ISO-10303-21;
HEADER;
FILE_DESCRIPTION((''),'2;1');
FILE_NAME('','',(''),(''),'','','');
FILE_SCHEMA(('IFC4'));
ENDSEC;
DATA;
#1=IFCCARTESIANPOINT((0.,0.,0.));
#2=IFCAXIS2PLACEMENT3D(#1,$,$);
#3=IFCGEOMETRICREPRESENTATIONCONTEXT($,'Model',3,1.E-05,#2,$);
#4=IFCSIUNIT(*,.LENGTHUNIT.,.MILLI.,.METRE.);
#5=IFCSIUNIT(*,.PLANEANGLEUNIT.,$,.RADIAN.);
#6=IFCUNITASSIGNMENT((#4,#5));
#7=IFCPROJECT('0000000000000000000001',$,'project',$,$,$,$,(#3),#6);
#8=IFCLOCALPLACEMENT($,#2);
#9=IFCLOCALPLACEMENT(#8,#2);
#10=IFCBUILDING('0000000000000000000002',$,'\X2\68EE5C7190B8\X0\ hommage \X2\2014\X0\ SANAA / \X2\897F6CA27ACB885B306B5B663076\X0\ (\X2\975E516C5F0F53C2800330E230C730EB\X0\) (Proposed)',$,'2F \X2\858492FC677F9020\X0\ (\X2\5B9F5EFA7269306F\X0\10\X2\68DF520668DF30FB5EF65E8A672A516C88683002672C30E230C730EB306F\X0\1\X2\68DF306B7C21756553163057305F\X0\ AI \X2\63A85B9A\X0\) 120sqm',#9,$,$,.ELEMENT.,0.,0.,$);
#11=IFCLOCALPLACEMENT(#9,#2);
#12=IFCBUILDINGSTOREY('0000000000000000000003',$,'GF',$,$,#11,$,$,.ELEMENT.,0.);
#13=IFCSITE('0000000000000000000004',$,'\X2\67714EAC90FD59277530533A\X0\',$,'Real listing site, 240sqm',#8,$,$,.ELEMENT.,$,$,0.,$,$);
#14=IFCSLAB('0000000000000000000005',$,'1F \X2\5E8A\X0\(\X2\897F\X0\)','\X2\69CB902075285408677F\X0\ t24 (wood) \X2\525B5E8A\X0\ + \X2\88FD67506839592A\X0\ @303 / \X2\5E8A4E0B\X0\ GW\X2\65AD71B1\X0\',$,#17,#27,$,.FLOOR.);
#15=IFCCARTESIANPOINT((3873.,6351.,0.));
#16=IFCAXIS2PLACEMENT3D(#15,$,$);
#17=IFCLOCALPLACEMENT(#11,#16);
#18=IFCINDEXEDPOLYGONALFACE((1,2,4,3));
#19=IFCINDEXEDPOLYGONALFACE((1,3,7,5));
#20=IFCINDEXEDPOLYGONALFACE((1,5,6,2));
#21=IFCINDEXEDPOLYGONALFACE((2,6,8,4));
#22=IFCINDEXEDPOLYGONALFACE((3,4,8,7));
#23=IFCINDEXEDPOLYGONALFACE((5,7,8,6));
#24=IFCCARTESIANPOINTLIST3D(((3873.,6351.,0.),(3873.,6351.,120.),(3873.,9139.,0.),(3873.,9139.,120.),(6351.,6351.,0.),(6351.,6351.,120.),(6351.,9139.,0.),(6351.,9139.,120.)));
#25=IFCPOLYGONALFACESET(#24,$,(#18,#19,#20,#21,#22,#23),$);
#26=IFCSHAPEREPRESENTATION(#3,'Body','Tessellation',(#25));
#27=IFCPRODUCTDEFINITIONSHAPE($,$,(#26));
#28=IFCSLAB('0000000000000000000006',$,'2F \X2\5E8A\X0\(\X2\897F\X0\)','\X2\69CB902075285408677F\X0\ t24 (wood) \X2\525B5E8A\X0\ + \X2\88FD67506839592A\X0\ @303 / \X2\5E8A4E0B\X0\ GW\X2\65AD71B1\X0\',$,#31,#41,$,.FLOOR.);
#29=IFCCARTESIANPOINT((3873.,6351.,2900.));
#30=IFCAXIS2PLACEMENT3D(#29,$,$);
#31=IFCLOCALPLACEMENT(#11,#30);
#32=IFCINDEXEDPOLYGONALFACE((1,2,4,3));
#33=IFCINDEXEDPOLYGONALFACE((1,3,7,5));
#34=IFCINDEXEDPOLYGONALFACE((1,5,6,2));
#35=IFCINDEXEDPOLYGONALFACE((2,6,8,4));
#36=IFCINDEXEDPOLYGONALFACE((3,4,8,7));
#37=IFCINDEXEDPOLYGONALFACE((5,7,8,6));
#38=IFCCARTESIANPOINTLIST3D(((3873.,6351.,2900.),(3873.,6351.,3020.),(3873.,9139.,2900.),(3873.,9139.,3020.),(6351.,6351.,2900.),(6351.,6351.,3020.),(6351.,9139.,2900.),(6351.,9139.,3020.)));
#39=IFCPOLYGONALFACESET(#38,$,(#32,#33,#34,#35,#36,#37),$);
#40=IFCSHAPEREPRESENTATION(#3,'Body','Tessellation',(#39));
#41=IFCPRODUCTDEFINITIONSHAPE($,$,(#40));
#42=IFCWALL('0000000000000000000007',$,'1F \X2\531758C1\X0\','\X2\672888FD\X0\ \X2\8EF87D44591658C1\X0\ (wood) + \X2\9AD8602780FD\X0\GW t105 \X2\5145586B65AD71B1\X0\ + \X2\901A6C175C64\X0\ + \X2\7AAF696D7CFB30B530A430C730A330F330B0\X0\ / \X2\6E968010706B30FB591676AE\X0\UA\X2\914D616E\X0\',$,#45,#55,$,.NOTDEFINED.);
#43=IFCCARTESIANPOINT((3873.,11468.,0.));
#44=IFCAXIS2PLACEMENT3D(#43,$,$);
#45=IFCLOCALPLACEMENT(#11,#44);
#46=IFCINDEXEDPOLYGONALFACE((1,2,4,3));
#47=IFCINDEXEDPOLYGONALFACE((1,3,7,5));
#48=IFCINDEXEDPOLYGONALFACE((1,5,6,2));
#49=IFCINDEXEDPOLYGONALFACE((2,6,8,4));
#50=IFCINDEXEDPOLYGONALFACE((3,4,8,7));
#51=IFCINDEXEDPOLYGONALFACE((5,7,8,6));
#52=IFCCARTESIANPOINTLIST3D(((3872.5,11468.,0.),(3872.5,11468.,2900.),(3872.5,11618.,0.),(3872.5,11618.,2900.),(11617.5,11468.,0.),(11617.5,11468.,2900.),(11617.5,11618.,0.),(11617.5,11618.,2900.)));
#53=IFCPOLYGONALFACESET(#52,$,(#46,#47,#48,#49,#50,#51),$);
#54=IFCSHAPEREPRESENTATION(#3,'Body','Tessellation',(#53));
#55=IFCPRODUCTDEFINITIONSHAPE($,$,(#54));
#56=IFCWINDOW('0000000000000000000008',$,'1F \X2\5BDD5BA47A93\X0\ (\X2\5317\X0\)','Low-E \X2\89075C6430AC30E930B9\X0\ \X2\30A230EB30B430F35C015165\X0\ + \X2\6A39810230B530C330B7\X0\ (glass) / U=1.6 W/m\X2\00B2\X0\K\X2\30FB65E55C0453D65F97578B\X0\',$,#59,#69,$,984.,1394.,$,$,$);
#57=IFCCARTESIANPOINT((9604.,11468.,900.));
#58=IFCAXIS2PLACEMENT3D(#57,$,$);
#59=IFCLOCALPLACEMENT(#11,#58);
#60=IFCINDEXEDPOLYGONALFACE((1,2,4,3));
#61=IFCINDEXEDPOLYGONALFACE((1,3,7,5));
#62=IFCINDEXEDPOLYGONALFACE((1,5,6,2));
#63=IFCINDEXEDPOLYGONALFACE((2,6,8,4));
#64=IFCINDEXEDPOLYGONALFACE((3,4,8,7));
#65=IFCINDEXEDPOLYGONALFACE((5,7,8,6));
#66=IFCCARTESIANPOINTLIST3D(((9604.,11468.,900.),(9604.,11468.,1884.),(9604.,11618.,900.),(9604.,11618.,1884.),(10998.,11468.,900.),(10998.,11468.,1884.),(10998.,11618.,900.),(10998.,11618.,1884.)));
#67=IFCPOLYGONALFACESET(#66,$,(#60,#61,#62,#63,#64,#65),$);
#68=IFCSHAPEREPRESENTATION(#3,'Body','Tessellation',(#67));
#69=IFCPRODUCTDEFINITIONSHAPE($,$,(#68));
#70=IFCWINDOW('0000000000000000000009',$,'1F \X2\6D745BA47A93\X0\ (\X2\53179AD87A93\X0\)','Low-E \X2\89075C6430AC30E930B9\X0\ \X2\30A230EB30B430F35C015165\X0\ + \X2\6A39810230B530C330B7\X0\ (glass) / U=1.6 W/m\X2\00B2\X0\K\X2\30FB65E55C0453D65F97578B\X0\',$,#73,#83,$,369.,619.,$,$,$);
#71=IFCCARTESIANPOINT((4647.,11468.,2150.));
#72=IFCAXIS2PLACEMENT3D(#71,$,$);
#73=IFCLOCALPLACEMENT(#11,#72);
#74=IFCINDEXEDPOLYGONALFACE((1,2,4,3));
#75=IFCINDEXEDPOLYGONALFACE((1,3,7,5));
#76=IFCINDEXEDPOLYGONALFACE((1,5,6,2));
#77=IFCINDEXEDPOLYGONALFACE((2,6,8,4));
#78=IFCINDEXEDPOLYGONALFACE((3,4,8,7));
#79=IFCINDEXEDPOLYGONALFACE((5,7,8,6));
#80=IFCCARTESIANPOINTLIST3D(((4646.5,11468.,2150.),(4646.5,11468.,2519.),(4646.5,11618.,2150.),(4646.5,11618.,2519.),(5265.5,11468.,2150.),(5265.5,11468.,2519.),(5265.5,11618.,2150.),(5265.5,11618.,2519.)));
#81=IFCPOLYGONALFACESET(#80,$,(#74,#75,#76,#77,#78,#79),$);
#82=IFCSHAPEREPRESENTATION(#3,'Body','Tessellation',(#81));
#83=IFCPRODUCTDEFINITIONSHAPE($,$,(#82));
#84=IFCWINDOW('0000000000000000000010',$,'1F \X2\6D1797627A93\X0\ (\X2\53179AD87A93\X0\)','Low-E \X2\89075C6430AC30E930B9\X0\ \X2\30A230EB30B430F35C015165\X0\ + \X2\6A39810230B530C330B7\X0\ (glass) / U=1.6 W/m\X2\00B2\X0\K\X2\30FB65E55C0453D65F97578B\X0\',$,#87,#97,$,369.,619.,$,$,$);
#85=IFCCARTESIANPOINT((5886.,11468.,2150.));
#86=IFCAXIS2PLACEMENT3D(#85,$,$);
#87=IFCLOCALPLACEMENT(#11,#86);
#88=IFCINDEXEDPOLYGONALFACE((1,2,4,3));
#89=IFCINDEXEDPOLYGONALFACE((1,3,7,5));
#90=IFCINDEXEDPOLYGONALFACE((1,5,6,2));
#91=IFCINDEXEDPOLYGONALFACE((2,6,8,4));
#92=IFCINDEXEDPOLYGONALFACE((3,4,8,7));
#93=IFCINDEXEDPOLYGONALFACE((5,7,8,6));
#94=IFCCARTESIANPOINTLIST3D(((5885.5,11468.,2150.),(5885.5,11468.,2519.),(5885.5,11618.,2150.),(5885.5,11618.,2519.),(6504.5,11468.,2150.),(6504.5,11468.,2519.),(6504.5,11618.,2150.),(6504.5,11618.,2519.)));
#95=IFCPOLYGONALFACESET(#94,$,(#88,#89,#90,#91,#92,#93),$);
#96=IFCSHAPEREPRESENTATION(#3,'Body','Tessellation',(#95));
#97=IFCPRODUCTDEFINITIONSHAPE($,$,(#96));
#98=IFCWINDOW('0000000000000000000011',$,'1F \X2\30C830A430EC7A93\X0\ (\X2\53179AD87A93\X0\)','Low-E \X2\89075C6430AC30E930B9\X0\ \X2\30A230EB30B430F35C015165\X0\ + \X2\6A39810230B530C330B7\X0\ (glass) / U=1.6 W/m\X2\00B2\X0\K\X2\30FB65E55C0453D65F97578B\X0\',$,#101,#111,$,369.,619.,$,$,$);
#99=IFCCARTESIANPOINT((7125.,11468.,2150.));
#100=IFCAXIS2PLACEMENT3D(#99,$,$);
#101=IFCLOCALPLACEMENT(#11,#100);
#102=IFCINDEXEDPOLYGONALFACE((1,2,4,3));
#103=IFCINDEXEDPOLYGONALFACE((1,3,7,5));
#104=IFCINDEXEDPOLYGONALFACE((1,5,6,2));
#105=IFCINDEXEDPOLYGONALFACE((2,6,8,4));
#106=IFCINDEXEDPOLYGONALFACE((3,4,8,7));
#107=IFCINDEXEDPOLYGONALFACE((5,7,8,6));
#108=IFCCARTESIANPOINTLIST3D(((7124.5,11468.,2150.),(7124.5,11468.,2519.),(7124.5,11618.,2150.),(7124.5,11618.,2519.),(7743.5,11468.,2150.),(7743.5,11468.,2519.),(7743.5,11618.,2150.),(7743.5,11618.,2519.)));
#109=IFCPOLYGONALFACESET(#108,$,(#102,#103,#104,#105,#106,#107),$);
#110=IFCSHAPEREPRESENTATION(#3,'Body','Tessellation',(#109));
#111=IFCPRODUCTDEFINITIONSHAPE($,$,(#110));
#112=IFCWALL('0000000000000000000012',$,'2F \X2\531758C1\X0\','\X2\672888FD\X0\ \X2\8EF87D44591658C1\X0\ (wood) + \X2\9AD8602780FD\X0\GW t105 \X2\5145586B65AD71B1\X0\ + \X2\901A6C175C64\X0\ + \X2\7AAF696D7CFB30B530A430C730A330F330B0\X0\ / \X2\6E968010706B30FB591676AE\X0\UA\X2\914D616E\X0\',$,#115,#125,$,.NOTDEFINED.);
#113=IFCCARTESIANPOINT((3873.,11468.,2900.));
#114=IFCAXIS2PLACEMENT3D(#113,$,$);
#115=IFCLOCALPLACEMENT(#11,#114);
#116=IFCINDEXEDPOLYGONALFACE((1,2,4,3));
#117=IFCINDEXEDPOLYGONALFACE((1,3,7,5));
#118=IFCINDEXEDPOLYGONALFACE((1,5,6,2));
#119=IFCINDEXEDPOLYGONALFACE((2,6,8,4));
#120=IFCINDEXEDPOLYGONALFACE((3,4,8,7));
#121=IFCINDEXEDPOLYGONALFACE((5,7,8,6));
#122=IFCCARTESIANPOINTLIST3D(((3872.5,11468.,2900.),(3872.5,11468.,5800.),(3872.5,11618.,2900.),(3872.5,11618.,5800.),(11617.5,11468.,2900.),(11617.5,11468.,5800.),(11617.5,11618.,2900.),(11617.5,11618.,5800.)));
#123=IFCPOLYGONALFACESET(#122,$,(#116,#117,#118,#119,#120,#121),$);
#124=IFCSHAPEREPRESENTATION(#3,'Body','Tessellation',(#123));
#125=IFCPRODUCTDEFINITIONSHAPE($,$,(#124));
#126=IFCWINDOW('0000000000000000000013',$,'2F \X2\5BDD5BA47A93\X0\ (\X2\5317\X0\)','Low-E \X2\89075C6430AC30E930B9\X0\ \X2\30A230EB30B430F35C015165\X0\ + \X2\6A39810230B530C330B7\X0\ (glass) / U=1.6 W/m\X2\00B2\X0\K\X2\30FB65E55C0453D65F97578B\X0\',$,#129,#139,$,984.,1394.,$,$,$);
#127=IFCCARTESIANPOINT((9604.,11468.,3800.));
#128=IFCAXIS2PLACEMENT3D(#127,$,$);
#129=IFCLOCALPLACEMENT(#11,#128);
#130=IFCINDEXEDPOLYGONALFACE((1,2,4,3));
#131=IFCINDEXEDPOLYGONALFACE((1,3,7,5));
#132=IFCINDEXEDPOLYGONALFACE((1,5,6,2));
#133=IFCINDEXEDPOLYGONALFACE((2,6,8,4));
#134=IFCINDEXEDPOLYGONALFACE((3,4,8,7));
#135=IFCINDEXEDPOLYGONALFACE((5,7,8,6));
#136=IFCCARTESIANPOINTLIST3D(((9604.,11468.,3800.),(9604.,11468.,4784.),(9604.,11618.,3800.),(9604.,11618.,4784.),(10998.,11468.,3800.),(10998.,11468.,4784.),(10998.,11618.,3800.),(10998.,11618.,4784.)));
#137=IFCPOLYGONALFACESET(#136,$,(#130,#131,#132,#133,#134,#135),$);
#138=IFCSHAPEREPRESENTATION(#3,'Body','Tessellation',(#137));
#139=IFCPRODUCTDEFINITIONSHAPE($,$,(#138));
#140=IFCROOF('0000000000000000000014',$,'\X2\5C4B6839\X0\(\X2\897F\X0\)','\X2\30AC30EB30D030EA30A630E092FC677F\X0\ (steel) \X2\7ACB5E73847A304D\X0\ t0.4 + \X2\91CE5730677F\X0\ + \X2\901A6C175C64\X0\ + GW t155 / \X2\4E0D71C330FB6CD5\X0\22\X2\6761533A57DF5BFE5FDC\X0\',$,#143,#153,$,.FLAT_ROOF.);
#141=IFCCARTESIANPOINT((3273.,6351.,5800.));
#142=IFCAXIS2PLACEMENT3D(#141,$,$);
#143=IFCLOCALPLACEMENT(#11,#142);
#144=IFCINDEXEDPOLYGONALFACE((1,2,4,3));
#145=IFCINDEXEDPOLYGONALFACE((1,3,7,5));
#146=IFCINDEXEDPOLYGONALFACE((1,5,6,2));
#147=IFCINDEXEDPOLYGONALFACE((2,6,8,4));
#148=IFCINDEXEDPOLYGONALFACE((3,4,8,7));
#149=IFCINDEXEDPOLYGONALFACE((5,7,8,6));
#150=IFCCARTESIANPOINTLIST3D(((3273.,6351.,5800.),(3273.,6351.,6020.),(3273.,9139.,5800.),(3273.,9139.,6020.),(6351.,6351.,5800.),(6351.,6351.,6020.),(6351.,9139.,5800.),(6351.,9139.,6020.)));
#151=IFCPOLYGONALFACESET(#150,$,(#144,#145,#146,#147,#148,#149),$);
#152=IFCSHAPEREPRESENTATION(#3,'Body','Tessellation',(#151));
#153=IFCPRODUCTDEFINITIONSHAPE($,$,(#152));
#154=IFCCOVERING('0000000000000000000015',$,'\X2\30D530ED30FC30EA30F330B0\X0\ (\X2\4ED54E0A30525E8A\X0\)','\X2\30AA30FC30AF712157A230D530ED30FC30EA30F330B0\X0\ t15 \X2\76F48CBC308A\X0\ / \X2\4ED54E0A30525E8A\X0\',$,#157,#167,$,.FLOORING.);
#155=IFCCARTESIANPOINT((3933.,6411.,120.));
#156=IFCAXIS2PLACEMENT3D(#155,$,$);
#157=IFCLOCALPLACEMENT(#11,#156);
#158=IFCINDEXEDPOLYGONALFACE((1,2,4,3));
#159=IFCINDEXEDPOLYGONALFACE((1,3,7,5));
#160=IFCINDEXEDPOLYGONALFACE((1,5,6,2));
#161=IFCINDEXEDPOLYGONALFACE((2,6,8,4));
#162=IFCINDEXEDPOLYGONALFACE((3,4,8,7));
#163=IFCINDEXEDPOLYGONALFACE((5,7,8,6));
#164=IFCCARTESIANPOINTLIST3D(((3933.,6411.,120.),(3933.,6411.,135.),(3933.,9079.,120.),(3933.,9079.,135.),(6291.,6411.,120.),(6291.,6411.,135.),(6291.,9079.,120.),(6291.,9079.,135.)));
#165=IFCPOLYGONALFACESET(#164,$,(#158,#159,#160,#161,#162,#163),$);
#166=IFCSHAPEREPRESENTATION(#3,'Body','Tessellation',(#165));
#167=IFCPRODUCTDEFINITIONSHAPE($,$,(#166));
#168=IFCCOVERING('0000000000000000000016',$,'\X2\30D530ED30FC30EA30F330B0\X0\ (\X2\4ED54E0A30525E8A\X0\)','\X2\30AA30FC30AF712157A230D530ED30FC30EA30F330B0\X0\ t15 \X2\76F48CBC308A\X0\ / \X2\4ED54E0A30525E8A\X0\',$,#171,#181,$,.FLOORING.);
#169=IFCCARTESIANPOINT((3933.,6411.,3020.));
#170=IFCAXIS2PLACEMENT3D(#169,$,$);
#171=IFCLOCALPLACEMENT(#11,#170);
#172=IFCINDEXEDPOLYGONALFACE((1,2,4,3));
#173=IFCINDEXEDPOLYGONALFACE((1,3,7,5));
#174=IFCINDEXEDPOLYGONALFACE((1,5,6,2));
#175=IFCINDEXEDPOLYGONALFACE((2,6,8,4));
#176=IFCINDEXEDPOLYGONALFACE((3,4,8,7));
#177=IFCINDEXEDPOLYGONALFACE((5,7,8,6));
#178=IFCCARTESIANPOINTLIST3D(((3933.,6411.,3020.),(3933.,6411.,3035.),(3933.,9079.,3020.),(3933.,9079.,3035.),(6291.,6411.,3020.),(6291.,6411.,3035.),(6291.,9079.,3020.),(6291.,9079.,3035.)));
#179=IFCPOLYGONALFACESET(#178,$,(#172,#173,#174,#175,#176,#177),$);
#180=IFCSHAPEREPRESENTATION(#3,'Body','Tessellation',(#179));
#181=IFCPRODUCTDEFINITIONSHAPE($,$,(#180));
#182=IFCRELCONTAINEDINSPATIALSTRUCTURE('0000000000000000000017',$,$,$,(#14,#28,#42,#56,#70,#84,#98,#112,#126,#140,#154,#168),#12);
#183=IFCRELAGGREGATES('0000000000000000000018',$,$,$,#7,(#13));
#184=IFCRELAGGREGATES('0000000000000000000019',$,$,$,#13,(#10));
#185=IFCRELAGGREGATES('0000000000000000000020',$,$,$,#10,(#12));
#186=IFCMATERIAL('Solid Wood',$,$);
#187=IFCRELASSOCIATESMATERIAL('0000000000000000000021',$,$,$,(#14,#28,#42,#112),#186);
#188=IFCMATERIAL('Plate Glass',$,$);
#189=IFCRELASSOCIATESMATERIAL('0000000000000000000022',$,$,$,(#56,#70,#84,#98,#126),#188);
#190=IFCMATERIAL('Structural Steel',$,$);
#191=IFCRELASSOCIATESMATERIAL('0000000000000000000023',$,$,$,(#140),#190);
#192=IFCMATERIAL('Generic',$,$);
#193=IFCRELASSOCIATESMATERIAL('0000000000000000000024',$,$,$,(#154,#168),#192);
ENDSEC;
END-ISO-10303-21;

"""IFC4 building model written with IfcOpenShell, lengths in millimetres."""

from ifc_helpers import new_model, si_unit, frame, frame_2d, origin, place, context, project, spatial, rectangle, extrude, material, element, fill, save


model = new_model("IFC4")

# Units and contexts
model_context = context("Model", 3, precision=1e-05, world=origin())
ifc_project = project(units=[si_unit("LENGTHUNIT", "METRE", prefix="MILLI"), si_unit("PLANEANGLEUNIT", "RADIAN")], contexts=[model_context])

# Site, building, storey
site_placement = place(None, origin())
site = spatial("IfcSite", under=ifc_project, at=site_placement, Name="東京都大田区", ObjectType="Real listing site, 240sqm", CompositionType="ELEMENT", RefElevation=0.0)
building_placement = place(site_placement, origin())
building = spatial("IfcBuilding", under=site, at=building_placement, Name="森山邸 hommage — SANAA / 西沢立衛に学ぶ (非公式参考モデル) (Proposed)", ObjectType="2F 薄鋼板造 (実建物は10棟分棟・延床未公表。本モデルは1棟に簡略化した AI 推定) 120sqm", CompositionType="ELEMENT", ElevationOfRefHeight=0.0, ElevationOfTerrain=0.0)
storey_placement = place(building_placement, origin())
storey = spatial("IfcBuildingStorey", under=building, at=storey_placement, Name="GF", CompositionType="ELEMENT", Elevation=0.0)

# Slabs
ifc_material_1 = material(Name="Solid Wood")
slab_1_placement = place(storey_placement, frame((3873.0, 6351.0, 0.0)))
element("IfcSlab", 1, at=slab_1_placement, inside=storey, material=ifc_material_1, Name="1F 床(西)", Description="構造用合板 t24 (wood) 剛床 + 製材根太 @303 / 床下 GW断熱", PredefinedType="FLOOR", context=model_context, shape_type="SweptSolid", body=[
    extrude(rectangle(XDim=2478.0, YDim=2788.0, at=frame_2d((1239.0, 1394.0))), frame((3873.0, 6351.0, 0.0)), (0.0, 0.0, 1.0), 120.0),
])
slab_2_placement = place(storey_placement, frame((3873.0, 6351.0, 2900.0)))
element("IfcSlab", 2, at=slab_2_placement, inside=storey, material=ifc_material_1, Name="2F 床(西)", Description="構造用合板 t24 (wood) 剛床 + 製材根太 @303 / 床下 GW断熱", PredefinedType="FLOOR", context=model_context, shape_type="SweptSolid", body=[
    extrude(rectangle(XDim=2478.0, YDim=2788.0, at=frame_2d((1239.0, 1394.0))), frame((3873.0, 6351.0, 2900.0)), (0.0, 0.0, 1.0), 120.0),
])

# Wall, openings, windows
wall_1_placement = place(storey_placement, frame((3873.0, 11468.0, 0.0)))
wall_1 = element("IfcWall", 3, at=wall_1_placement, inside=storey, material=ifc_material_1, Name="1F 北壁", Description="木製 軸組外壁 (wood) + 高性能GW t105 充填断熱 + 通気層 + 窯業系サイディング / 準耐火・外皮UA配慮", PredefinedType="NOTDEFINED", context=model_context, shape_type="SweptSolid", body=[
    extrude(rectangle(XDim=7745.0, YDim=150.0, at=frame_2d((3872.0, 75.0))), frame((3873.0, 11468.0, 0.0)), (0.0, 0.0, 1.0), 2900.0),
])
opening_1_placement = place(storey_placement, frame((9604.0, 11468.0, 900.0)))
opening_1 = element("IfcOpeningElement", 4, at=opening_1_placement, cuts=wall_1, PredefinedType="NOTDEFINED", context=model_context, shape_type="SweptSolid", body=[
    extrude(rectangle(XDim=1394.0, YDim=150.0, at=frame_2d((697.0, 75.0))), frame((9604.0, 11468.0, 900.0)), (0.0, 0.0, 1.0), 984.0),
])
opening_2_placement = place(storey_placement, frame((4647.0, 11468.0, 2150.0)))
opening_2 = element("IfcOpeningElement", 5, at=opening_2_placement, cuts=wall_1, PredefinedType="NOTDEFINED", context=model_context, shape_type="SweptSolid", body=[
    extrude(rectangle(XDim=619.0, YDim=150.0, at=frame_2d((309.0, 75.0))), frame((4647.0, 11468.0, 2150.0)), (0.0, 0.0, 1.0), 369.0),
])
opening_3_placement = place(storey_placement, frame((5886.0, 11468.0, 2150.0)))
opening_3 = element("IfcOpeningElement", 6, at=opening_3_placement, cuts=wall_1, PredefinedType="NOTDEFINED", context=model_context, shape_type="SweptSolid", body=[
    extrude(rectangle(XDim=619.0, YDim=150.0, at=frame_2d((309.0, 75.0))), frame((5886.0, 11468.0, 2150.0)), (0.0, 0.0, 1.0), 369.0),
])
opening_4_placement = place(storey_placement, frame((7125.0, 11468.0, 2150.0)))
opening_4 = element("IfcOpeningElement", 7, at=opening_4_placement, cuts=wall_1, PredefinedType="NOTDEFINED", context=model_context, shape_type="SweptSolid", body=[
    extrude(rectangle(XDim=619.0, YDim=150.0, at=frame_2d((309.0, 75.0))), frame((7125.0, 11468.0, 2150.0)), (0.0, 0.0, 1.0), 369.0),
])
ifc_material_2 = material(Name="Plate Glass")
window_1_placement = place(storey_placement, frame((9604.0, 11468.0, 900.0)))
window_1 = element("IfcWindow", 8, at=window_1_placement, inside=storey, material=ifc_material_2, Name="1F 寝室窓 (北)", Description="Low-E 複層ガラス アルゴン封入 + 樹脂サッシ (glass) / U=1.6 W/m²K・日射取得型", OverallHeight=984.0, OverallWidth=1394.0, context=model_context, shape_type="SweptSolid", body=[
    extrude(rectangle(XDim=1394.0, YDim=150.0, at=frame_2d((697.0, 75.0))), frame((9604.0, 11468.0, 900.0)), (0.0, 0.0, 1.0), 984.0),
])
fill(opening_1, window_1)
window_2_placement = place(storey_placement, frame((4647.0, 11468.0, 2150.0)))
window_2 = element("IfcWindow", 9, at=window_2_placement, inside=storey, material=ifc_material_2, Name="1F 浴室窓 (北高窓)", Description="Low-E 複層ガラス アルゴン封入 + 樹脂サッシ (glass) / U=1.6 W/m²K・日射取得型", OverallHeight=369.0, OverallWidth=619.0, context=model_context, shape_type="SweptSolid", body=[
    extrude(rectangle(XDim=619.0, YDim=150.0, at=frame_2d((309.0, 75.0))), frame((4647.0, 11468.0, 2150.0)), (0.0, 0.0, 1.0), 369.0),
])
fill(opening_2, window_2)
window_3_placement = place(storey_placement, frame((5886.0, 11468.0, 2150.0)))
window_3 = element("IfcWindow", 10, at=window_3_placement, inside=storey, material=ifc_material_2, Name="1F 洗面窓 (北高窓)", Description="Low-E 複層ガラス アルゴン封入 + 樹脂サッシ (glass) / U=1.6 W/m²K・日射取得型", OverallHeight=369.0, OverallWidth=619.0, context=model_context, shape_type="SweptSolid", body=[
    extrude(rectangle(XDim=619.0, YDim=150.0, at=frame_2d((309.0, 75.0))), frame((5886.0, 11468.0, 2150.0)), (0.0, 0.0, 1.0), 369.0),
])
fill(opening_3, window_3)
window_4_placement = place(storey_placement, frame((7125.0, 11468.0, 2150.0)))
window_4 = element("IfcWindow", 11, at=window_4_placement, inside=storey, material=ifc_material_2, Name="1F トイレ窓 (北高窓)", Description="Low-E 複層ガラス アルゴン封入 + 樹脂サッシ (glass) / U=1.6 W/m²K・日射取得型", OverallHeight=369.0, OverallWidth=619.0, context=model_context, shape_type="SweptSolid", body=[
    extrude(rectangle(XDim=619.0, YDim=150.0, at=frame_2d((309.0, 75.0))), frame((7125.0, 11468.0, 2150.0)), (0.0, 0.0, 1.0), 369.0),
])
fill(opening_4, window_4)

# Wall, opening, window
wall_2_placement = place(storey_placement, frame((3873.0, 11468.0, 2900.0)))
wall_2 = element("IfcWall", 12, at=wall_2_placement, inside=storey, material=ifc_material_1, Name="2F 北壁", Description="木製 軸組外壁 (wood) + 高性能GW t105 充填断熱 + 通気層 + 窯業系サイディング / 準耐火・外皮UA配慮", PredefinedType="NOTDEFINED", context=model_context, shape_type="SweptSolid", body=[
    extrude(rectangle(XDim=7745.0, YDim=150.0, at=frame_2d((3872.0, 75.0))), frame((3873.0, 11468.0, 2900.0)), (0.0, 0.0, 1.0), 2900.0),
])
opening_5_placement = place(storey_placement, frame((9604.0, 11468.0, 3800.0)))
opening_5 = element("IfcOpeningElement", 13, at=opening_5_placement, cuts=wall_2, PredefinedType="NOTDEFINED", context=model_context, shape_type="SweptSolid", body=[
    extrude(rectangle(XDim=1394.0, YDim=150.0, at=frame_2d((697.0, 75.0))), frame((9604.0, 11468.0, 3800.0)), (0.0, 0.0, 1.0), 984.0),
])
window_5_placement = place(storey_placement, frame((9604.0, 11468.0, 3800.0)))
window_5 = element("IfcWindow", 14, at=window_5_placement, inside=storey, material=ifc_material_2, Name="2F 寝室窓 (北)", Description="Low-E 複層ガラス アルゴン封入 + 樹脂サッシ (glass) / U=1.6 W/m²K・日射取得型", OverallHeight=984.0, OverallWidth=1394.0, context=model_context, shape_type="SweptSolid", body=[
    extrude(rectangle(XDim=1394.0, YDim=150.0, at=frame_2d((697.0, 75.0))), frame((9604.0, 11468.0, 3800.0)), (0.0, 0.0, 1.0), 984.0),
])
fill(opening_5, window_5)

# Roof
ifc_material_3 = material(Name="Structural Steel")
roof_placement = place(storey_placement, frame((3273.0, 6351.0, 5800.0)))
element("IfcRoof", 15, at=roof_placement, inside=storey, material=ifc_material_3, Name="屋根(西)", Description="ガルバリウム鋼板 (steel) 立平葺き t0.4 + 野地板 + 通気層 + GW t155 / 不燃・法22条区域対応", PredefinedType="FLAT_ROOF", context=model_context, shape_type="SweptSolid", body=[
    extrude(rectangle(XDim=3078.0, YDim=2788.0, at=frame_2d((1539.0, 1394.0))), frame((3273.0, 6351.0, 5800.0)), (0.0, 0.0, 1.0), 220.0),
])

# Coverings
ifc_material_4 = material(Name="Generic")
covering_1_placement = place(storey_placement, frame((3933.0, 6411.0, 120.0)))
element("IfcCovering", 16, at=covering_1_placement, inside=storey, material=ifc_material_4, Name="フローリング (仕上げ床)", Description="オーク無垢フローリング t15 直貼り / 仕上げ床", PredefinedType="FLOORING", context=model_context, shape_type="SweptSolid", body=[
    extrude(rectangle(XDim=2358.0, YDim=2668.0, at=frame_2d((1179.0, 1334.0))), frame((3933.0, 6411.0, 120.0)), (0.0, 0.0, 1.0), 15.0),
])
covering_2_placement = place(storey_placement, frame((3933.0, 6411.0, 3020.0)))
element("IfcCovering", 17, at=covering_2_placement, inside=storey, material=ifc_material_4, Name="フローリング (仕上げ床)", Description="オーク無垢フローリング t15 直貼り / 仕上げ床", PredefinedType="FLOORING", context=model_context, shape_type="SweptSolid", body=[
    extrude(rectangle(XDim=2358.0, YDim=2668.0, at=frame_2d((1179.0, 1334.0))), frame((3933.0, 6411.0, 3020.0)), (0.0, 0.0, 1.0), 15.0),
])

save(model, "model.ifc")
